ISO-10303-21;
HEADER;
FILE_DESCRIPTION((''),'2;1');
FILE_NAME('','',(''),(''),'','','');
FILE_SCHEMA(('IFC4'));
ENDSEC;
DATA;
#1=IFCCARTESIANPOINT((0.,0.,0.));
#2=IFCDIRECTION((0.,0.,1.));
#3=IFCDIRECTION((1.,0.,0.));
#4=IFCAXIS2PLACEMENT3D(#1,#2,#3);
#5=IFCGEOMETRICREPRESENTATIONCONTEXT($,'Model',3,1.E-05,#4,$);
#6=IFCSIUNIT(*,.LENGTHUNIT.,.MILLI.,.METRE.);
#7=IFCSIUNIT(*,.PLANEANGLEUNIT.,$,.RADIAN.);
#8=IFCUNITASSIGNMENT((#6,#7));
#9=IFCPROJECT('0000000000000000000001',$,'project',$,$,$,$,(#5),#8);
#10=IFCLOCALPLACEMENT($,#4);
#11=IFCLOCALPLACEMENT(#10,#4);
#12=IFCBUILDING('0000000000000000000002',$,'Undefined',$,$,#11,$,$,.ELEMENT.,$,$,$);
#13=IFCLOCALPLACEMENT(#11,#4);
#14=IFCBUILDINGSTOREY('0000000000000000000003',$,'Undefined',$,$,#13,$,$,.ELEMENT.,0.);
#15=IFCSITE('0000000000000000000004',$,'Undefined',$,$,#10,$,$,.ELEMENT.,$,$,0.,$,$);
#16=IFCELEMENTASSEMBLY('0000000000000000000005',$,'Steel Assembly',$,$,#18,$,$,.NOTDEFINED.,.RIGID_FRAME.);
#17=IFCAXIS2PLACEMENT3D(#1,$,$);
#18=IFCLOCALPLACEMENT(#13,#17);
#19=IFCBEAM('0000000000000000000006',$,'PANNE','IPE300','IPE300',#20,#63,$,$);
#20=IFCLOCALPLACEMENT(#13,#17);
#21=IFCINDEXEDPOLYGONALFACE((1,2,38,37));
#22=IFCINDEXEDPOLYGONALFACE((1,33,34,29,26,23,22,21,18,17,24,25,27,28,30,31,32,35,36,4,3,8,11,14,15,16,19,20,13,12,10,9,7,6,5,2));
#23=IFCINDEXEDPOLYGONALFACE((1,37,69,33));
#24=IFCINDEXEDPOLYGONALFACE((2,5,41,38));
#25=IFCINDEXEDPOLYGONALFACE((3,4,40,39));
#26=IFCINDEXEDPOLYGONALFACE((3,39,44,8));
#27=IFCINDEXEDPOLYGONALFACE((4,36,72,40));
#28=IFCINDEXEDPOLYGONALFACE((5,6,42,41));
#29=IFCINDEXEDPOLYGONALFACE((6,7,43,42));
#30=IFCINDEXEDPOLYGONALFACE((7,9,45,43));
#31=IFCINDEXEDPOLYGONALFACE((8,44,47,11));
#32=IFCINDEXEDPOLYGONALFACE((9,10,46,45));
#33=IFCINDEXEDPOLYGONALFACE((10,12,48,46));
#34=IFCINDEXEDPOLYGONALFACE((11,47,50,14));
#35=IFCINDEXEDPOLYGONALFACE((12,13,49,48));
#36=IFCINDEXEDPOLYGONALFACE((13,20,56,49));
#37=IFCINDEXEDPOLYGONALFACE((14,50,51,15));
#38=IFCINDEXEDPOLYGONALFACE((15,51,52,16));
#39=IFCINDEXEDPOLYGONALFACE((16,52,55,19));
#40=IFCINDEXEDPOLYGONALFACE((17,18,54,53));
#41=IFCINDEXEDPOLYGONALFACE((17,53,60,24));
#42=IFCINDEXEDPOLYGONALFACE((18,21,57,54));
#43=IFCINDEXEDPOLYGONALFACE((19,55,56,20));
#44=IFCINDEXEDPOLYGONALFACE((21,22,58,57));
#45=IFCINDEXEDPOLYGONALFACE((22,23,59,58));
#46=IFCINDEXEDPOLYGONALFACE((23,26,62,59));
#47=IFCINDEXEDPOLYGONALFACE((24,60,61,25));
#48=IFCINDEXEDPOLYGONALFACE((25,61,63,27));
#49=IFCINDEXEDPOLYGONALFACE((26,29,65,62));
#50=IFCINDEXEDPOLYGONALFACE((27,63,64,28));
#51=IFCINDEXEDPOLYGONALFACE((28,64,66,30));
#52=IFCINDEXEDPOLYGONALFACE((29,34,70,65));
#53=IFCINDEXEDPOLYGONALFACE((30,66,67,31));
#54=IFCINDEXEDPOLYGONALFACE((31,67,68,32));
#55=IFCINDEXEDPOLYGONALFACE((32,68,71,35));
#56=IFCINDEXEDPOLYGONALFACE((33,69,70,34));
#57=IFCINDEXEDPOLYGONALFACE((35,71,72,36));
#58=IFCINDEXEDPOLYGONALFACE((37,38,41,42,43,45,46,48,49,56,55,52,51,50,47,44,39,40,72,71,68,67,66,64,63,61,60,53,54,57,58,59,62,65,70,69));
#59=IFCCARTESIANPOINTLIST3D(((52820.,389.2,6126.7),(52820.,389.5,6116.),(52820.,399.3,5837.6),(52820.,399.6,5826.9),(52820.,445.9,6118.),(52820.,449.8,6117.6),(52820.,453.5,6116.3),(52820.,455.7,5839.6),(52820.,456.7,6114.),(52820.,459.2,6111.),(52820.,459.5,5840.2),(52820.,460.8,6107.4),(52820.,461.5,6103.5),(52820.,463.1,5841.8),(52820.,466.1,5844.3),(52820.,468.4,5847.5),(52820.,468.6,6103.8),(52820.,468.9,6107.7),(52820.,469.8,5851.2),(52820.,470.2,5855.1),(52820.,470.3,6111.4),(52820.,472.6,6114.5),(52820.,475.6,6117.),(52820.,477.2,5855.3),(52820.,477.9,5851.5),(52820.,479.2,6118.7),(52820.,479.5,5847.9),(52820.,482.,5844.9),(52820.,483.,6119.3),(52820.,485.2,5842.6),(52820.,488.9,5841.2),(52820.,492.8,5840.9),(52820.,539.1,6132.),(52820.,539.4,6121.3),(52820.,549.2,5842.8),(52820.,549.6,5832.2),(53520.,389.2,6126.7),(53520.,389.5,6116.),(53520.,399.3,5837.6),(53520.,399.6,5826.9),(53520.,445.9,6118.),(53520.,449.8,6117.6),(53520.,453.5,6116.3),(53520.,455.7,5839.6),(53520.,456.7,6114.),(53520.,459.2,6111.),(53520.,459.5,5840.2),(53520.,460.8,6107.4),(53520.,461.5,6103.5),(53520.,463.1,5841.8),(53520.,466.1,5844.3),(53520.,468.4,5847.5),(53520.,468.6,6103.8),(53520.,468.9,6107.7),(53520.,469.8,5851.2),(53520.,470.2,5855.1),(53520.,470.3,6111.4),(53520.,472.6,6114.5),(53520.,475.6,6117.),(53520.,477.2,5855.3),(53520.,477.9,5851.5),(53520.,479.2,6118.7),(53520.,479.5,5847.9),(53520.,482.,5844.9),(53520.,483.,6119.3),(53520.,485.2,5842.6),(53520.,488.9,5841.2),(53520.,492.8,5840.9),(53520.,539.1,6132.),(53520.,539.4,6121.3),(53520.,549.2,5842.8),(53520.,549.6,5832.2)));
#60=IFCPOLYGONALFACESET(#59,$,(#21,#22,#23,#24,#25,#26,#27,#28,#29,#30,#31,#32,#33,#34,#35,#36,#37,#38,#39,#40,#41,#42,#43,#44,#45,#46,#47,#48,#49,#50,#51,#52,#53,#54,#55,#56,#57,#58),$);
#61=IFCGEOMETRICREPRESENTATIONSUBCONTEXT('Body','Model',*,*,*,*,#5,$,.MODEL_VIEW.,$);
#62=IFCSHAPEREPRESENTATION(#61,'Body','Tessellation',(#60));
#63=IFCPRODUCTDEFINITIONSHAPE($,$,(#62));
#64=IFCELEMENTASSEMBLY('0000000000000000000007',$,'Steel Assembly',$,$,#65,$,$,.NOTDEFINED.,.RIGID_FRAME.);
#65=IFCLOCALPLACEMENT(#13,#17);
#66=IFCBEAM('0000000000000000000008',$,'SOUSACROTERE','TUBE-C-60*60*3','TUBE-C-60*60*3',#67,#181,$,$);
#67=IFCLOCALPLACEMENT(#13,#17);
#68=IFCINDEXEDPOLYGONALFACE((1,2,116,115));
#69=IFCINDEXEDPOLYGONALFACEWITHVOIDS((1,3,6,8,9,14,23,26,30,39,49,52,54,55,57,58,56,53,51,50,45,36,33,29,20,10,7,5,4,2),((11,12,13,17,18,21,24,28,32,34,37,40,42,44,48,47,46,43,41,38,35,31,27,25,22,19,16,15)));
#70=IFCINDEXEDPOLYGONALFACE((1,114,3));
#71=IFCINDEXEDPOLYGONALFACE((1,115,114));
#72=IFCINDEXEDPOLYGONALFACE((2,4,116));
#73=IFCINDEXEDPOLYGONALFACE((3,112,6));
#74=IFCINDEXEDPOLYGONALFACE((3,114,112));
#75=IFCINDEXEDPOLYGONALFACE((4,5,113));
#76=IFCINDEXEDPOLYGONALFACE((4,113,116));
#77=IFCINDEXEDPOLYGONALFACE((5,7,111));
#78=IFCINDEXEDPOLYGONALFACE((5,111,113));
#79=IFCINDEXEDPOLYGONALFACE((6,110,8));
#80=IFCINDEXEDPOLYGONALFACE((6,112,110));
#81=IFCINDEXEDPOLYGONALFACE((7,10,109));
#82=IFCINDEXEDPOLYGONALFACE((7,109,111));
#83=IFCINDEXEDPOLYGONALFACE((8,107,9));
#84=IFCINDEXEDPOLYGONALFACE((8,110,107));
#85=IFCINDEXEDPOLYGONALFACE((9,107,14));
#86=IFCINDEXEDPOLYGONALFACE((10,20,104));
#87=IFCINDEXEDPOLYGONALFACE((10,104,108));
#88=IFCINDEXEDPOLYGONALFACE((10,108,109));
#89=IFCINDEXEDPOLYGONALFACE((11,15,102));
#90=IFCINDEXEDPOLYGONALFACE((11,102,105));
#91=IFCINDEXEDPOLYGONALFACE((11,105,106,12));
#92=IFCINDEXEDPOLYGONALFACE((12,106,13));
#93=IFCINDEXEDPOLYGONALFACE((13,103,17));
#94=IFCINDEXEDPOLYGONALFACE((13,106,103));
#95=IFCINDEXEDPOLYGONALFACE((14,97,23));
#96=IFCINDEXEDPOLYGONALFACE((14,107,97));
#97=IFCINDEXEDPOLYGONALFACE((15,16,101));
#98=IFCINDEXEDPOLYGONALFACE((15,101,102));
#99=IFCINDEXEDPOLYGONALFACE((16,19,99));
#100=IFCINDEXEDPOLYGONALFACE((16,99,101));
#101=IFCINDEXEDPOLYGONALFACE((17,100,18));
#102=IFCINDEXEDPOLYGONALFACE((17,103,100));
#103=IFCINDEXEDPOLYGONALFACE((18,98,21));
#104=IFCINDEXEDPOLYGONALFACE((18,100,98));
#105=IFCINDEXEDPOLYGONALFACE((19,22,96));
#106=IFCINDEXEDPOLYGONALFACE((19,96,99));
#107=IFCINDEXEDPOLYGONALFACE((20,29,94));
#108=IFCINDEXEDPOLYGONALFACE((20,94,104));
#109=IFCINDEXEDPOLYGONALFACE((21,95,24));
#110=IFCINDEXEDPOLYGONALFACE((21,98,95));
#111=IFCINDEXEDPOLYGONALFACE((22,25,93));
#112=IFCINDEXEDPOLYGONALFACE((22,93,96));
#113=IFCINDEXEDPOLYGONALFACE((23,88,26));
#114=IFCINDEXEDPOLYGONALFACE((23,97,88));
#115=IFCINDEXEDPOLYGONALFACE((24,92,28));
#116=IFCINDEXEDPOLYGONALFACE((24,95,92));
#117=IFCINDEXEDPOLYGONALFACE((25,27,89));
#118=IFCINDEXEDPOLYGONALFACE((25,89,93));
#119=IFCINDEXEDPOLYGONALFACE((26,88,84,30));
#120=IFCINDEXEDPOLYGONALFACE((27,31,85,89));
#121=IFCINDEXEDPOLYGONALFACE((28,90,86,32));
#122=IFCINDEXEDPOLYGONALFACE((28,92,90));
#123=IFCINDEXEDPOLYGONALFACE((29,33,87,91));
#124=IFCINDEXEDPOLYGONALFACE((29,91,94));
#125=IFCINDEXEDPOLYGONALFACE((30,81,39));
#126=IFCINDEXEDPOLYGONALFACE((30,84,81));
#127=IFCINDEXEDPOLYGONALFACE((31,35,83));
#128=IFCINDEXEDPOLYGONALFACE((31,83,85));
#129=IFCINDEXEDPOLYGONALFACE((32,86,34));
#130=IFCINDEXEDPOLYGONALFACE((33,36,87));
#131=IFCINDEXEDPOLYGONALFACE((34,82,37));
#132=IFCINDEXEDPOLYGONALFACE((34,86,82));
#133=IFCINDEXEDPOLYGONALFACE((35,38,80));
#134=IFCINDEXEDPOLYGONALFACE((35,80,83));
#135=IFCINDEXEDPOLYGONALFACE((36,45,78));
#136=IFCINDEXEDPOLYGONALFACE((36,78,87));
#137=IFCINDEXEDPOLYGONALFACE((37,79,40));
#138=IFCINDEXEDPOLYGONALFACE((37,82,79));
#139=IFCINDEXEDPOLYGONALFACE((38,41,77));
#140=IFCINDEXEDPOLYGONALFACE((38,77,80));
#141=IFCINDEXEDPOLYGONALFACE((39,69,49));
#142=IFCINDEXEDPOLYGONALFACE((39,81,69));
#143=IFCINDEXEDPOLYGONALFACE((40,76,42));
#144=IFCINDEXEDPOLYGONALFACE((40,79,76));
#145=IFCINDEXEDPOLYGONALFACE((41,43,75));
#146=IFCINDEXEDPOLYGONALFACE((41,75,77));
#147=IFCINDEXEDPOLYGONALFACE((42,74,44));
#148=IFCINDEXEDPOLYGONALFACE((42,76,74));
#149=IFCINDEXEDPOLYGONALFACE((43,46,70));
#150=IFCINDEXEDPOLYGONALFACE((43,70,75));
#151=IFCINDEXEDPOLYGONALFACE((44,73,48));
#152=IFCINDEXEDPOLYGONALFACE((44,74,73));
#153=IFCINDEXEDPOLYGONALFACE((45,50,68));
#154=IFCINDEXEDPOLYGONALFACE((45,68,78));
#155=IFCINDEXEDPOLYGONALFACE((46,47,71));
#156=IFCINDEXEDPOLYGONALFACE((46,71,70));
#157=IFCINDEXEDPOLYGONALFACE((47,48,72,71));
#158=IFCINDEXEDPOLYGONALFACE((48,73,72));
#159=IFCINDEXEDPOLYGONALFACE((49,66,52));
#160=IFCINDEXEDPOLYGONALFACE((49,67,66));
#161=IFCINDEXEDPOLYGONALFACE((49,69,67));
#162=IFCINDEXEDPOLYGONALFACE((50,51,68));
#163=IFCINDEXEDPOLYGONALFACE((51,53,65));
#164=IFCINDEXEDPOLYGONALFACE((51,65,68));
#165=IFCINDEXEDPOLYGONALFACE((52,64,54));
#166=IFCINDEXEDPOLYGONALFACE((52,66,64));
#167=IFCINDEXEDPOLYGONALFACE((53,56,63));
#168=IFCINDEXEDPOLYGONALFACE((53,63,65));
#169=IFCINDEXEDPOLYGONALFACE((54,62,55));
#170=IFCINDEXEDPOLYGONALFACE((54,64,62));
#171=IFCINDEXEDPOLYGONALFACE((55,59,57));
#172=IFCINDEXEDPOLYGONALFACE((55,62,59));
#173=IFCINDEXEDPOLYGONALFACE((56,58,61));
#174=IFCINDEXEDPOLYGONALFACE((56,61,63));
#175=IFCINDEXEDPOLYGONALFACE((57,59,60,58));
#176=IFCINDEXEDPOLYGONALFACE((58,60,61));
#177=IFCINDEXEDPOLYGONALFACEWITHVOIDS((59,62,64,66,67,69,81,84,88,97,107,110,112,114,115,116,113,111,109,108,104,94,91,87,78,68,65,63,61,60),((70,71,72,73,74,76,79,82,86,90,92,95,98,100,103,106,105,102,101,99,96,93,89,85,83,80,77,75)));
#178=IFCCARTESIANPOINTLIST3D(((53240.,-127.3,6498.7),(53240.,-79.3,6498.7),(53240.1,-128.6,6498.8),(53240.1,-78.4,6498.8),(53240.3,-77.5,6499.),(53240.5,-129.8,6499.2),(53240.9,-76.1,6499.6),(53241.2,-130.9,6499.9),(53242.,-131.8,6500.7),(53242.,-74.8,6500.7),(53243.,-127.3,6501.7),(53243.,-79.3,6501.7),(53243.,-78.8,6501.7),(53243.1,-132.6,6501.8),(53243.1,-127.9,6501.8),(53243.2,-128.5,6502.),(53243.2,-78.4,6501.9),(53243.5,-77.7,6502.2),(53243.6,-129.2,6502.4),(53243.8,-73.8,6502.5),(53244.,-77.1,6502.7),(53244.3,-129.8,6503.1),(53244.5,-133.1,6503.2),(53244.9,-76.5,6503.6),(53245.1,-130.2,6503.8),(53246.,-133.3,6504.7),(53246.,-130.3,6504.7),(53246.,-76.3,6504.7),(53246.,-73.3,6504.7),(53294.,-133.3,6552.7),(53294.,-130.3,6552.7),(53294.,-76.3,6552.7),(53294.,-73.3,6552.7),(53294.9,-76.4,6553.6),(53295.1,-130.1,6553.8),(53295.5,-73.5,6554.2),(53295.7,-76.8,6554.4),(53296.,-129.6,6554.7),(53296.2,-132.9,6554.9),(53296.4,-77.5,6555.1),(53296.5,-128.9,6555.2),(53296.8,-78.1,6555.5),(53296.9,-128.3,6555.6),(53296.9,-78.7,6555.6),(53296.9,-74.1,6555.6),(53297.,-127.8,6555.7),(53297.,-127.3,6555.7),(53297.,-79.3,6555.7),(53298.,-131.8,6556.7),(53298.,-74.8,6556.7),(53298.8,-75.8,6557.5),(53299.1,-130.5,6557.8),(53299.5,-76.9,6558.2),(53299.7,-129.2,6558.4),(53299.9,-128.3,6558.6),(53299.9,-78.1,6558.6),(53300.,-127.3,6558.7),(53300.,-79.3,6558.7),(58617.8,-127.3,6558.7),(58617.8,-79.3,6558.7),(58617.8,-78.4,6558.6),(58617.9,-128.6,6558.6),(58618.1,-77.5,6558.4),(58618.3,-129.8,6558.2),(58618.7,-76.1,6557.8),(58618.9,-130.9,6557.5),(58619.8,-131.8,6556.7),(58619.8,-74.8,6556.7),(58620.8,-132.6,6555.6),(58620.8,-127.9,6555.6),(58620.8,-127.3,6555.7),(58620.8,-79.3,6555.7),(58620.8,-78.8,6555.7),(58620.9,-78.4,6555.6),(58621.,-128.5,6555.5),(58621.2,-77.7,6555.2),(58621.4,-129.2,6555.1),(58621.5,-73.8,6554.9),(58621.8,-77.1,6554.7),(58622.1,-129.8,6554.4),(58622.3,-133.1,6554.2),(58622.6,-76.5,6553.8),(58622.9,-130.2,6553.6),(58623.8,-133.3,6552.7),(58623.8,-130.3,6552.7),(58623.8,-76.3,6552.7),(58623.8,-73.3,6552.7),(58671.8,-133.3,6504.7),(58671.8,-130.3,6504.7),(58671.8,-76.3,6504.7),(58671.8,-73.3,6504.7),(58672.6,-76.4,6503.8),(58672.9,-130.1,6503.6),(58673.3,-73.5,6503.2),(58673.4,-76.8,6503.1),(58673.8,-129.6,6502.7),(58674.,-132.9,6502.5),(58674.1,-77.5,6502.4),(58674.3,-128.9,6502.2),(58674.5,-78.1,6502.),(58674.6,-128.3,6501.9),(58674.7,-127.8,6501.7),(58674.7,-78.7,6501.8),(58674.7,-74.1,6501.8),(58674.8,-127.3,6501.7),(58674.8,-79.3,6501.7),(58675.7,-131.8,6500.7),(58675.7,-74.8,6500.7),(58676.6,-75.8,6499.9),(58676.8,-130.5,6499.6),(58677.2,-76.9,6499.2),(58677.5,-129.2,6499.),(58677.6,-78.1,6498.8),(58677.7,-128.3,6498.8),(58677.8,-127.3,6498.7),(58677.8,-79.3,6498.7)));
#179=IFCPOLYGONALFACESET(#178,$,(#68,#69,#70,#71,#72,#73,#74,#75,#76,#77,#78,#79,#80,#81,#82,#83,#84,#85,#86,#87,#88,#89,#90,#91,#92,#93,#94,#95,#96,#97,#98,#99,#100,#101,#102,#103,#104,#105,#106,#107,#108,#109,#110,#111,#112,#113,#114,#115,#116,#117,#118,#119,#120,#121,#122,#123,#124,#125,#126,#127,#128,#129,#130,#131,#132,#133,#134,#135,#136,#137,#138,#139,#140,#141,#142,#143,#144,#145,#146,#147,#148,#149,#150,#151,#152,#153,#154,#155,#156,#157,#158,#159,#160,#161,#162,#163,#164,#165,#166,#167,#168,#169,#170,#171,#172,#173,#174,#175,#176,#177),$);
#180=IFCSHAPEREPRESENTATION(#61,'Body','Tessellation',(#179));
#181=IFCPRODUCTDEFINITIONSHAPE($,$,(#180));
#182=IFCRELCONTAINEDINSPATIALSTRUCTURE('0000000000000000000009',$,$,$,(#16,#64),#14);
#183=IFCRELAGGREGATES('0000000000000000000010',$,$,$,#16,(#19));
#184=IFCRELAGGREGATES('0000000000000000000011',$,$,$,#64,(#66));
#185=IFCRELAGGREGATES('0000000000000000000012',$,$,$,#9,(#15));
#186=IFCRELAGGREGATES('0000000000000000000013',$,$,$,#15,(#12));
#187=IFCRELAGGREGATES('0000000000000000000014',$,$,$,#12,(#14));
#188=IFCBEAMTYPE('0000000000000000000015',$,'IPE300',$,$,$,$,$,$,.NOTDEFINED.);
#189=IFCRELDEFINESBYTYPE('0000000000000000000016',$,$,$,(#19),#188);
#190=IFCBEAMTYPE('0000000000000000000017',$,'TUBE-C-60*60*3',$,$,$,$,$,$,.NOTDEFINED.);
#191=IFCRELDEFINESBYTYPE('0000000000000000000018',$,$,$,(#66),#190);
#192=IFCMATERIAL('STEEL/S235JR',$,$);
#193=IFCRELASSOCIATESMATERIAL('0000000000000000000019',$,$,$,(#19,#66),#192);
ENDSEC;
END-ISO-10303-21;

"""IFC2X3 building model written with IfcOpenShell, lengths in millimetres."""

from ifc_helpers import new_model, si_unit, frame, origin_with_axes, origin_2d_with_axis, place, context, subcontext, project, spatial, hollow_rectangle, i_section, extrude, clip, halfspace, material, type_object, element, aggregate, save


model = new_model("IFC2X3")

# Units and contexts
model_context = context("Model", 3, precision=1e-05, world=origin_with_axes())
body_context = subcontext(model_context, "Body", "Model", "MODEL_VIEW")
ifc_project = project(units=[si_unit("LENGTHUNIT", "METRE", prefix="MILLI"), si_unit("PLANEANGLEUNIT", "RADIAN")], contexts=[model_context])

# Site, building, storey
site_placement = place(None, origin_with_axes())
site = spatial("IfcSite", under=ifc_project, at=site_placement, Name="Undefined", CompositionType="ELEMENT", RefElevation=0.0)
building_placement = place(site_placement, origin_with_axes())
building = spatial("IfcBuilding", under=site, at=building_placement, Name="Undefined", CompositionType="ELEMENT")
storey_placement = place(building_placement, origin_with_axes())
storey = spatial("IfcBuildingStorey", under=building, at=storey_placement, Name="Undefined", CompositionType="ELEMENT", Elevation=0.0)

# Element assemblies, beams
assembly_1_placement = place(storey_placement, origin_with_axes())
assembly_1 = element("IfcElementAssembly", 1, at=assembly_1_placement, inside=storey, Name="Steel Assembly", AssemblyPlace="NOTDEFINED", PredefinedType="RIGID_FRAME")
ifc_material_1 = material(Name="STEEL/S235JR")
beam_type_1 = type_object("IfcBeamType", Name="IPE300", PredefinedType="NOTDEFINED")
beam_1_placement = place(assembly_1_placement, frame((53520.0, 469.4, 5979.4), z_axis=(0.0, -0.034979, 0.999388), x_axis=(-1.0, 0.0, 0.0)))
beam_1 = element("IfcBeam", 2, at=beam_1_placement, type_object=beam_type_1, material=ifc_material_1, Name="PANNE", Description="IPE300", ObjectType="IPE300", context=body_context, shape_type="SweptSolid", body=[
    extrude(i_section(OverallWidth=150.0, OverallDepth=300.0, WebThickness=7.1, FlangeThickness=10.7, FilletRadius=15.0, at=origin_2d_with_axis()), frame((700.0, 0.0, 0.0), z_axis=(-1.0, 0.0, 0.0), x_axis=(0.0, -1.0, 0.0)), (0.0, 0.0, 1.0), 700.0),
])
aggregate(assembly_1, [beam_1])
assembly_2_placement = place(storey_placement, origin_with_axes())
assembly_2 = element("IfcElementAssembly", 3, at=assembly_2_placement, inside=storey, Name="Steel Assembly", AssemblyPlace="NOTDEFINED", PredefinedType="RIGID_FRAME")
beam_type_2 = type_object("IfcBeamType", Name="TUBE-C-60*60*3", PredefinedType="NOTDEFINED")
beam_2_placement = place(assembly_2_placement, frame((58747.8, -103.3, 6528.7), z_axis=(0.0, 0.0, 1.0), x_axis=(-1.0, 0.0, 0.0)))
beam_2 = element("IfcBeam", 4, at=beam_2_placement, type_object=beam_type_2, material=ifc_material_1, Name="SOUSACROTERE", Description="TUBE-C-60*60*3", ObjectType="TUBE-C-60*60*3", context=body_context, shape_type="Clipping", body=[
    clip(clip(extrude(hollow_rectangle(XDim=60.0, YDim=60.0, WallThickness=3.0, InnerFilletRadius=3.0, OuterFilletRadius=6.0, at=origin_2d_with_axis()), frame((5577.8, 0.0, 0.0), z_axis=(-1.0, 0.0, 0.0), x_axis=(0.0, -1.0, 0.0)), (0.0, 0.0, 1.0), 5577.8), halfspace(frame((5507.8, -30.0, -30.0), z_axis=(0.707107, 0.0, 0.707107), x_axis=(-0.707107, 0.0, 0.707107)), False)), halfspace(frame((70.0, 30.0, -30.0), z_axis=(-0.707107, 0.0, 0.707107), x_axis=(0.707107, 0.0, 0.707107)), False)),
])

aggregate(assembly_2, [beam_2])

save(model, "model.ifc")
